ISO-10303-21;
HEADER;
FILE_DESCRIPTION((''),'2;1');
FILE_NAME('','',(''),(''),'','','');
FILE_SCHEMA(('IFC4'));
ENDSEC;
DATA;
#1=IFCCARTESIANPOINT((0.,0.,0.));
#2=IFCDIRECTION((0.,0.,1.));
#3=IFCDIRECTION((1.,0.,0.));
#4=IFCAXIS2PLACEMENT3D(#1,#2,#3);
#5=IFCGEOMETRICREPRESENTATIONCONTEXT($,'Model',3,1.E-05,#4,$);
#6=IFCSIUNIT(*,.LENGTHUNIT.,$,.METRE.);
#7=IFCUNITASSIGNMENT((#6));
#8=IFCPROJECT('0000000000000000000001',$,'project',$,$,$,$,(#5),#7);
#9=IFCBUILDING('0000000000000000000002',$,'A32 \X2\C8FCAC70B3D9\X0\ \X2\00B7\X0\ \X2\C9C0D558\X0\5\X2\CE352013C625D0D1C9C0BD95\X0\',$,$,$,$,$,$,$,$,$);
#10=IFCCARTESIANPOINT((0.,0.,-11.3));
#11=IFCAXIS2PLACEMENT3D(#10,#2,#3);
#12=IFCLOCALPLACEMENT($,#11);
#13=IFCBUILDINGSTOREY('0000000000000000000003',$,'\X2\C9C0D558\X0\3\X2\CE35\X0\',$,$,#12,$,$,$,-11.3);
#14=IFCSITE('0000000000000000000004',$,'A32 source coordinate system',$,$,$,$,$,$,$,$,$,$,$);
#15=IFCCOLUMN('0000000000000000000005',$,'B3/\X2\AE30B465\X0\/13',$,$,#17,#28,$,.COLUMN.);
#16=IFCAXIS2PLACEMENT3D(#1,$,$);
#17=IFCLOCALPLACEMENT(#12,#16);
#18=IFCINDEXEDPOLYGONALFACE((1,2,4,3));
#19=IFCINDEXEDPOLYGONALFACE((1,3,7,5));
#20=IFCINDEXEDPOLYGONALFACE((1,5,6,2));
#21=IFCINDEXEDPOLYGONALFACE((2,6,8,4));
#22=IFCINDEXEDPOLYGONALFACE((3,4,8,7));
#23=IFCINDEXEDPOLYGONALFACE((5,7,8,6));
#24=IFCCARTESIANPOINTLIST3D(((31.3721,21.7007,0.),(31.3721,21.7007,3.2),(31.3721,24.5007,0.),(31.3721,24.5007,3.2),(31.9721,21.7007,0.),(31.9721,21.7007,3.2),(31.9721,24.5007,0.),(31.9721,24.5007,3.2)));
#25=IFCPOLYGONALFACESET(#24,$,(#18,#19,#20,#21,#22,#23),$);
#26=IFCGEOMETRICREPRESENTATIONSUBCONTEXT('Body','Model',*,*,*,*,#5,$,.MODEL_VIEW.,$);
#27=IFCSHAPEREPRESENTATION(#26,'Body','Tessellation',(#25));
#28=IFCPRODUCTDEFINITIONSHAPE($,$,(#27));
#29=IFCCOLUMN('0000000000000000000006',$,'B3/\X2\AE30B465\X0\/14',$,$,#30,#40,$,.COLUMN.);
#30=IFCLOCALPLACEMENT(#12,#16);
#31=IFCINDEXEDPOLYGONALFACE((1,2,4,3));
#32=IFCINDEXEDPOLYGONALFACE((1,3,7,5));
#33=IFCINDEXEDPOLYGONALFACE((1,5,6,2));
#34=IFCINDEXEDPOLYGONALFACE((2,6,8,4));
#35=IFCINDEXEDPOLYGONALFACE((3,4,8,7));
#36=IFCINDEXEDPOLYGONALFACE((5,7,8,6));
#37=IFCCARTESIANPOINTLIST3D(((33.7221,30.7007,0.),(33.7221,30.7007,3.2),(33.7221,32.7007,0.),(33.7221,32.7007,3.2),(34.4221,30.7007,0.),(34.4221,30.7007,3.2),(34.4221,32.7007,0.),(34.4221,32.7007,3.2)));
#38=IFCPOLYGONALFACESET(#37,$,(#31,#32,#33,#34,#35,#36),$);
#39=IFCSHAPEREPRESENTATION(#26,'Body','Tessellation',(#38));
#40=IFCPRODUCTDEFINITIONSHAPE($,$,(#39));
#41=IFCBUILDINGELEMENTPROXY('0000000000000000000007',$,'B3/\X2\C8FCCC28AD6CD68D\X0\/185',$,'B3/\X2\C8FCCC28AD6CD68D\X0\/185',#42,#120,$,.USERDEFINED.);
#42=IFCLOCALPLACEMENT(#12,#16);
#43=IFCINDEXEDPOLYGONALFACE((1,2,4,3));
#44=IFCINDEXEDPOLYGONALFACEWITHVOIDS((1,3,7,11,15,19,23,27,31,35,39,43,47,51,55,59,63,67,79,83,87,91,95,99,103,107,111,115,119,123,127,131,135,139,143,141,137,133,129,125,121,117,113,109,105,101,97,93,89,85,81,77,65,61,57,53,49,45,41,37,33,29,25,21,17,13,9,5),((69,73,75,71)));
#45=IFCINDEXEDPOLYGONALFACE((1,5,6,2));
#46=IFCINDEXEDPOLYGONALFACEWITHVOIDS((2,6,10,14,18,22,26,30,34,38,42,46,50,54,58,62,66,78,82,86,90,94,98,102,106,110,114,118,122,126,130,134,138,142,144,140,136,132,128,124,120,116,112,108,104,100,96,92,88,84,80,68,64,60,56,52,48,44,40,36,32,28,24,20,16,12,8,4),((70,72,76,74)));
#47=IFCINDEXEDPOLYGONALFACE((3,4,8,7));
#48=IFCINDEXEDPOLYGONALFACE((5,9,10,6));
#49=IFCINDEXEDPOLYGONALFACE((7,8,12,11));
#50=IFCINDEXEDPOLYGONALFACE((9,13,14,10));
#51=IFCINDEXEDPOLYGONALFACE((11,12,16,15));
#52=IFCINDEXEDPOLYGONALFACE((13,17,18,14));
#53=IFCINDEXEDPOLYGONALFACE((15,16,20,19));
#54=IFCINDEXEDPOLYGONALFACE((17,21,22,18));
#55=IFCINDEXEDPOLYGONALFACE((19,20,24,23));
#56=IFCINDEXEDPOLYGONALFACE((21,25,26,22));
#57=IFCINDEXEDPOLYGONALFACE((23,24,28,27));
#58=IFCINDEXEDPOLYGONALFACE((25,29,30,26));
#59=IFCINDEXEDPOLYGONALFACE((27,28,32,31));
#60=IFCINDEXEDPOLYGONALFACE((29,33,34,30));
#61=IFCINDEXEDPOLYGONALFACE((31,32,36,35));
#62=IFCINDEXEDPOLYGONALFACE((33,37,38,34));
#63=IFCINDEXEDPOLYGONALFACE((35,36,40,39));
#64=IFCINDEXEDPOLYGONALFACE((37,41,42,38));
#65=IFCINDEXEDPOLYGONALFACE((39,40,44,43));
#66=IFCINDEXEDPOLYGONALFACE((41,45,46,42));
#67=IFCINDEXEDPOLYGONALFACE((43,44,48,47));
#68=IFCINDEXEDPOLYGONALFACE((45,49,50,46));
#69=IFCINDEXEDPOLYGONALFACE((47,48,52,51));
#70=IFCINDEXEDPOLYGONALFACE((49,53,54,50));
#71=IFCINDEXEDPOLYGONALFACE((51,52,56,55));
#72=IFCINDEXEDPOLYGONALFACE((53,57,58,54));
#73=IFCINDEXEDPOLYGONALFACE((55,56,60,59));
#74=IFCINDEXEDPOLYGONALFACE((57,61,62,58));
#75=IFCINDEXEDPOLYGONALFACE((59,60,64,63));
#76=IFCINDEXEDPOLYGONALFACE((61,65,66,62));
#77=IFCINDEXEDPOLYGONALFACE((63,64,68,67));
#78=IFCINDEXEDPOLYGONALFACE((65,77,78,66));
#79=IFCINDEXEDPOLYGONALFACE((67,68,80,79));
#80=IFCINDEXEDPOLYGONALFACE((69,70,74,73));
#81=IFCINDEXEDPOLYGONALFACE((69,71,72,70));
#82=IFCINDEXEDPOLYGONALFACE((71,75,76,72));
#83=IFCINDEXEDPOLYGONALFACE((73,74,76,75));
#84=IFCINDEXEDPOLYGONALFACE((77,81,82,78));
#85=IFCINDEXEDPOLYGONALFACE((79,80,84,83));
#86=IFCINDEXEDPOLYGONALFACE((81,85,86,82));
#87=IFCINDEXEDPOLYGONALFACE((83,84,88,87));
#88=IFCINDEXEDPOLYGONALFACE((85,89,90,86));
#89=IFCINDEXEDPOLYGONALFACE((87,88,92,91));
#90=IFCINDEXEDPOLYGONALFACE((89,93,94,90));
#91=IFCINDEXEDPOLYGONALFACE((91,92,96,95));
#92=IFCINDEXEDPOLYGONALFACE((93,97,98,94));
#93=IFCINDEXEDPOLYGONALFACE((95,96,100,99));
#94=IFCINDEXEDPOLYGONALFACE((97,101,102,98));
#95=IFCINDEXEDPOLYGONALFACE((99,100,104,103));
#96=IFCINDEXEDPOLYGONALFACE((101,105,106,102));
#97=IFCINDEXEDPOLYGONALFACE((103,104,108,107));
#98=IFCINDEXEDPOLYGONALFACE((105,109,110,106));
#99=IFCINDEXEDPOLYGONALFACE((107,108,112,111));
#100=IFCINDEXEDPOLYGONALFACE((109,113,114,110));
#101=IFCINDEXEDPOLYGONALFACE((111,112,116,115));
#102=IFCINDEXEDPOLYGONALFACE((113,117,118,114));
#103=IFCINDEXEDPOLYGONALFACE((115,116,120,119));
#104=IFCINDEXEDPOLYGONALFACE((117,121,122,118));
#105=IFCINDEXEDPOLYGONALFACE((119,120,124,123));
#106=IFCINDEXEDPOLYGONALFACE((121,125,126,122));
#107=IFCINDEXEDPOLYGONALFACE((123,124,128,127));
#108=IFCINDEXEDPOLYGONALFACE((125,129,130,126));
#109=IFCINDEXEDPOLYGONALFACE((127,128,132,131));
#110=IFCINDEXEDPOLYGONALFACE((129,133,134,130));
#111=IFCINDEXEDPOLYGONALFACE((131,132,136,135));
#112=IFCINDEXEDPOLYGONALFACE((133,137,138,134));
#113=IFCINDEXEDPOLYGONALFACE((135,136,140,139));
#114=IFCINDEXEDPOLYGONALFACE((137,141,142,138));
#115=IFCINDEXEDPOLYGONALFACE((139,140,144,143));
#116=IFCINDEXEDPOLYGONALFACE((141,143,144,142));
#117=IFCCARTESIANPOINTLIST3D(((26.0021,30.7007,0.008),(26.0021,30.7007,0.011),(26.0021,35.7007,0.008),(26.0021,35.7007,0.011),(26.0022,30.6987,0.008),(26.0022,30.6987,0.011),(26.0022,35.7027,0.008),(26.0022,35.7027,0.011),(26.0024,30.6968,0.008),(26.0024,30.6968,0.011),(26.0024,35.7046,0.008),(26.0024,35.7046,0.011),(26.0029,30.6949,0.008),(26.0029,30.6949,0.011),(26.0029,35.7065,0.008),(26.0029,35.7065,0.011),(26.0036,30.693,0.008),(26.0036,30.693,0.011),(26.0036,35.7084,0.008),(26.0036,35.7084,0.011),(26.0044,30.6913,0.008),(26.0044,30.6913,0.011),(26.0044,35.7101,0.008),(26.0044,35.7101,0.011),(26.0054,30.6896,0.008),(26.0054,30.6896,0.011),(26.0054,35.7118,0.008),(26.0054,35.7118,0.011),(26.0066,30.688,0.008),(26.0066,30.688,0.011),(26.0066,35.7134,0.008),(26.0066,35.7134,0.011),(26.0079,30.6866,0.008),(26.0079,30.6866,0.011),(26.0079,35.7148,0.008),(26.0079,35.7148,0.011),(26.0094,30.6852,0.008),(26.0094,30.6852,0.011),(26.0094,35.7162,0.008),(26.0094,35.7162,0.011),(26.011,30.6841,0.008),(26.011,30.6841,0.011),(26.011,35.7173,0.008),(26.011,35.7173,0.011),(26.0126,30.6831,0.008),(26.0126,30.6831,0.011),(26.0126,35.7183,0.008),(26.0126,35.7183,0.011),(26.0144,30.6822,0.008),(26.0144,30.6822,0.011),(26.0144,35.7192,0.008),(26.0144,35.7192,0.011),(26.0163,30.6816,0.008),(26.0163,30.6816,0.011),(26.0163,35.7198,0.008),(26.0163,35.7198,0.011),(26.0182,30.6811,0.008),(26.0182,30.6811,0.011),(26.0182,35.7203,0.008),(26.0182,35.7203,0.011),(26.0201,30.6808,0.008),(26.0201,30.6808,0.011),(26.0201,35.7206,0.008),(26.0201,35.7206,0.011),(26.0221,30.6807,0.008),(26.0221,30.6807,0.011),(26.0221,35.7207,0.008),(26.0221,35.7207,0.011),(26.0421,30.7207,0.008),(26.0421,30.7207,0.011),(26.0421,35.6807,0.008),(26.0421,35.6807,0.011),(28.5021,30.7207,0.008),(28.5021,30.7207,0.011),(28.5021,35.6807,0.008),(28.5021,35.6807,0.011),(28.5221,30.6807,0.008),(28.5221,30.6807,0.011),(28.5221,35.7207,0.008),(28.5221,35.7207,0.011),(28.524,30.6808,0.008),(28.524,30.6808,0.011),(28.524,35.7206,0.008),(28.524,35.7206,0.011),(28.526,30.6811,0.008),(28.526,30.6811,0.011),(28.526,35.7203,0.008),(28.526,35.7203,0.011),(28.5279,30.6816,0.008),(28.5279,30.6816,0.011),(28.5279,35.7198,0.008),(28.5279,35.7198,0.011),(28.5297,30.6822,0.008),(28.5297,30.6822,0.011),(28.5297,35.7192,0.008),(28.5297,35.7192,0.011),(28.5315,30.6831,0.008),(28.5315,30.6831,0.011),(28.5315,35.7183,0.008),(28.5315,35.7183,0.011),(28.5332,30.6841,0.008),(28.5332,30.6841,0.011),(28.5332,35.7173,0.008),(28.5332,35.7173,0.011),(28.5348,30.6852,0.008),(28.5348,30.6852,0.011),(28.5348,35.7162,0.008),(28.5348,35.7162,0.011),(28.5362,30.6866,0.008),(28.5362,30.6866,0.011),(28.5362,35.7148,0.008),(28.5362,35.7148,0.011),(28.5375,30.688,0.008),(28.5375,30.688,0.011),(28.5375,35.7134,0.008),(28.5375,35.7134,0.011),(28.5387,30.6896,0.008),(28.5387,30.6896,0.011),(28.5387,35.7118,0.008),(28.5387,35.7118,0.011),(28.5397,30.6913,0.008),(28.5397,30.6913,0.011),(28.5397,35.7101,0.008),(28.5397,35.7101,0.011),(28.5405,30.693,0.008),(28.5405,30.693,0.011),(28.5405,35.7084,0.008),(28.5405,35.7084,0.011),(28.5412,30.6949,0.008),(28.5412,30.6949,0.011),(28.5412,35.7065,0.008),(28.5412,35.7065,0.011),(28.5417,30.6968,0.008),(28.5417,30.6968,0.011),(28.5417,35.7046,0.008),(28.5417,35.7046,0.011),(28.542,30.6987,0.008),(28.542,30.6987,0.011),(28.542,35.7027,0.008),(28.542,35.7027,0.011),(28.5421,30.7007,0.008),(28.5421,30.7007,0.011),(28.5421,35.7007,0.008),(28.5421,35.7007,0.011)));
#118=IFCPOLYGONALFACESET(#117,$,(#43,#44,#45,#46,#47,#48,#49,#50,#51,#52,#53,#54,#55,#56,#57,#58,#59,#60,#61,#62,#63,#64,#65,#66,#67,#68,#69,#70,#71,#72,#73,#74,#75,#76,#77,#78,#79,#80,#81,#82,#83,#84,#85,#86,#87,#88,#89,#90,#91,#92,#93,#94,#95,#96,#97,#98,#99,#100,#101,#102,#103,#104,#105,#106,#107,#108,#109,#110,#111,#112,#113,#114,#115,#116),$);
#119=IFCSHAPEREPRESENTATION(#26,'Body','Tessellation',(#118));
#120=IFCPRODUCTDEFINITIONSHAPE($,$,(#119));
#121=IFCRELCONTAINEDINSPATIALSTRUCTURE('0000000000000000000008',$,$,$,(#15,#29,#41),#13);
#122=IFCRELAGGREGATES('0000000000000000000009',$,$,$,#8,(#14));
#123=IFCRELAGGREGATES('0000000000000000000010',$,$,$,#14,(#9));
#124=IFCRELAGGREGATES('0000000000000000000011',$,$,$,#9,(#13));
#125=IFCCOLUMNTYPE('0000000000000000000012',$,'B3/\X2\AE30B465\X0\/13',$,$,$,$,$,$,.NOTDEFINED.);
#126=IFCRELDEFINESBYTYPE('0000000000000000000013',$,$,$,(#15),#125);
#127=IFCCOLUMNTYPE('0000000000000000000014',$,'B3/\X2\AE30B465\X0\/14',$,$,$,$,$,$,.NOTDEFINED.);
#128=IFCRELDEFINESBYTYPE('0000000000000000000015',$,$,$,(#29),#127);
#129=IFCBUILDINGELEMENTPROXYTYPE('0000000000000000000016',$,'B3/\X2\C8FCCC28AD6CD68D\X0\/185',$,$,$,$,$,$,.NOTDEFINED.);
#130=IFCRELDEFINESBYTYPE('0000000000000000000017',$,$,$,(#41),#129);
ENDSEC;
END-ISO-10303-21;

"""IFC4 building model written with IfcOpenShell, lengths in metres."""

from ifc_helpers import new_model, si_unit, frame, origin, origin_with_axes, place, context, subcontext, project, spatial, polyline, outline, extrude, source, transform, mapped, type_object, type_shapes, element, save


model = new_model("IFC4")

# Units and contexts
model_context = context("Model", 3, precision=1e-05, world=origin_with_axes())
body_context = subcontext(model_context, "Body", "Model", "MODEL_VIEW")
ifc_project = project(units=[si_unit("LENGTHUNIT", "METRE")], contexts=[model_context])

# Site, building, storey
site = spatial("IfcSite", under=ifc_project, Name="A32 source coordinate system")
building = spatial("IfcBuilding", under=site, Name="A32 주거동 · 지하5층–옥탑지붕")
storey_placement = place(None, frame((0.0, 0.0, -11.3), z_axis=(0.0, 0.0, 1.0), x_axis=(1.0, 0.0, 0.0)))
storey = spatial("IfcBuildingStorey", under=building, at=storey_placement, Name="지하3층", Elevation=-11.3)

# Columns
column_type_1 = type_object("IfcColumnType", Name="B3/기둥/13", PredefinedType="NOTDEFINED")
shared_shape_1 = source(origin(), body_context, "Body", "SweptSolid", [
    extrude(outline(polyline([(31.9721, 21.7007), (31.3721, 21.7007), (31.3721, 24.5007), (31.9721, 24.5007), (31.9721, 21.7007)])), origin(), (0.0, 0.0, 1.0), 3.2),
])
type_shapes(column_type_1, [shared_shape_1])
column_1_placement = place(storey_placement, origin_with_axes())
element("IfcColumn", 1, at=column_1_placement, inside=storey, type_object=column_type_1, Name="B3/기둥/13", PredefinedType="COLUMN", context=body_context, shape_type="MappedRepresentation", body=[
    mapped(shared_shape_1, transform((0.0, 0.0, 0.0), scale=1.0)),
])
column_type_2 = type_object("IfcColumnType", Name="B3/기둥/14", PredefinedType="NOTDEFINED")
shared_shape_2 = source(origin(), body_context, "Body", "SweptSolid", [
    extrude(outline(polyline([(34.4221, 32.7007), (34.4221, 30.7007), (33.7221, 30.7007), (33.7221, 32.7007), (34.4221, 32.7007)])), origin(), (0.0, 0.0, 1.0), 3.2),
])
type_shapes(column_type_2, [shared_shape_2])
column_2_placement = place(storey_placement, origin_with_axes())
element("IfcColumn", 2, at=column_2_placement, inside=storey, type_object=column_type_2, Name="B3/기둥/14", PredefinedType="COLUMN", context=body_context, shape_type="MappedRepresentation", body=[
    mapped(shared_shape_2, transform((0.0, 0.0, 0.0), scale=1.0)),
])

# Building element proxy
building_element_proxy_type_1 = type_object("IfcBuildingElementProxyType", Name="B3/주차구획/185", PredefinedType="NOTDEFINED")
shared_shape_3 = source(origin(), body_context, "Body", "SweptSolid", [
    extrude(outline(polyline([(26.0021, 35.7007), (26.0022, 35.7027), (26.0024, 35.7046), (26.0029, 35.7065), (26.0036, 35.7084), (26.0044, 35.7101), (26.0054, 35.7118), (26.0066, 35.7134), (26.0079, 35.7148), (26.0094, 35.7162), (26.011, 35.7173), (26.0126, 35.7183), (26.0144, 35.7192), (26.0163, 35.7198), (26.0182, 35.7203), (26.0201, 35.7206), (26.0221, 35.7207), (28.5221, 35.7207), (28.524, 35.7206), (28.526, 35.7203), (28.5279, 35.7198), (28.5297, 35.7192), (28.5315, 35.7183), (28.5332, 35.7173), (28.5348, 35.7162), (28.5362, 35.7148), (28.5375, 35.7134), (28.5387, 35.7118), (28.5397, 35.7101), (28.5405, 35.7084), (28.5412, 35.7065), (28.5417, 35.7046), (28.542, 35.7027), (28.5421, 35.7007), (28.5421, 30.7007), (28.542, 30.6987), (28.5417, 30.6968), (28.5412, 30.6949), (28.5405, 30.693), (28.5397, 30.6913), (28.5387, 30.6896), (28.5375, 30.688), (28.5362, 30.6866), (28.5348, 30.6852), (28.5332, 30.6841), (28.5315, 30.6831), (28.5297, 30.6822), (28.5279, 30.6816), (28.526, 30.6811), (28.524, 30.6808), (28.5221, 30.6807), (26.0221, 30.6807), (26.0201, 30.6808), (26.0182, 30.6811), (26.0163, 30.6816), (26.0144, 30.6822), (26.0126, 30.6831), (26.011, 30.6841), (26.0094, 30.6852), (26.0079, 30.6866), (26.0066, 30.688), (26.0054, 30.6896), (26.0044, 30.6913), (26.0036, 30.693), (26.0029, 30.6949), (26.0024, 30.6968), (26.0022, 30.6987), (26.0021, 30.7007), (26.0021, 35.7007)]), holes=[polyline([(26.0421, 35.6807), (26.0421, 30.7207), (28.5021, 30.7207), (28.5021, 35.6807), (26.0421, 35.6807)])]), frame((0.0, 0.0, 0.008)), (0.0, 0.0, 1.0), 0.003),
])
type_shapes(building_element_proxy_type_1, [shared_shape_3])
proxy_1_placement = place(storey_placement, origin_with_axes())
element("IfcBuildingElementProxy", 3, at=proxy_1_placement, inside=storey, type_object=building_element_proxy_type_1, Name="B3/주차구획/185", ObjectType="B3/주차구획/185", PredefinedType="USERDEFINED", context=body_context, shape_type="MappedRepresentation", body=[
    mapped(shared_shape_3, transform((0.0, 0.0, 0.0), scale=1.0)),
])

save(model, "model.ifc")
